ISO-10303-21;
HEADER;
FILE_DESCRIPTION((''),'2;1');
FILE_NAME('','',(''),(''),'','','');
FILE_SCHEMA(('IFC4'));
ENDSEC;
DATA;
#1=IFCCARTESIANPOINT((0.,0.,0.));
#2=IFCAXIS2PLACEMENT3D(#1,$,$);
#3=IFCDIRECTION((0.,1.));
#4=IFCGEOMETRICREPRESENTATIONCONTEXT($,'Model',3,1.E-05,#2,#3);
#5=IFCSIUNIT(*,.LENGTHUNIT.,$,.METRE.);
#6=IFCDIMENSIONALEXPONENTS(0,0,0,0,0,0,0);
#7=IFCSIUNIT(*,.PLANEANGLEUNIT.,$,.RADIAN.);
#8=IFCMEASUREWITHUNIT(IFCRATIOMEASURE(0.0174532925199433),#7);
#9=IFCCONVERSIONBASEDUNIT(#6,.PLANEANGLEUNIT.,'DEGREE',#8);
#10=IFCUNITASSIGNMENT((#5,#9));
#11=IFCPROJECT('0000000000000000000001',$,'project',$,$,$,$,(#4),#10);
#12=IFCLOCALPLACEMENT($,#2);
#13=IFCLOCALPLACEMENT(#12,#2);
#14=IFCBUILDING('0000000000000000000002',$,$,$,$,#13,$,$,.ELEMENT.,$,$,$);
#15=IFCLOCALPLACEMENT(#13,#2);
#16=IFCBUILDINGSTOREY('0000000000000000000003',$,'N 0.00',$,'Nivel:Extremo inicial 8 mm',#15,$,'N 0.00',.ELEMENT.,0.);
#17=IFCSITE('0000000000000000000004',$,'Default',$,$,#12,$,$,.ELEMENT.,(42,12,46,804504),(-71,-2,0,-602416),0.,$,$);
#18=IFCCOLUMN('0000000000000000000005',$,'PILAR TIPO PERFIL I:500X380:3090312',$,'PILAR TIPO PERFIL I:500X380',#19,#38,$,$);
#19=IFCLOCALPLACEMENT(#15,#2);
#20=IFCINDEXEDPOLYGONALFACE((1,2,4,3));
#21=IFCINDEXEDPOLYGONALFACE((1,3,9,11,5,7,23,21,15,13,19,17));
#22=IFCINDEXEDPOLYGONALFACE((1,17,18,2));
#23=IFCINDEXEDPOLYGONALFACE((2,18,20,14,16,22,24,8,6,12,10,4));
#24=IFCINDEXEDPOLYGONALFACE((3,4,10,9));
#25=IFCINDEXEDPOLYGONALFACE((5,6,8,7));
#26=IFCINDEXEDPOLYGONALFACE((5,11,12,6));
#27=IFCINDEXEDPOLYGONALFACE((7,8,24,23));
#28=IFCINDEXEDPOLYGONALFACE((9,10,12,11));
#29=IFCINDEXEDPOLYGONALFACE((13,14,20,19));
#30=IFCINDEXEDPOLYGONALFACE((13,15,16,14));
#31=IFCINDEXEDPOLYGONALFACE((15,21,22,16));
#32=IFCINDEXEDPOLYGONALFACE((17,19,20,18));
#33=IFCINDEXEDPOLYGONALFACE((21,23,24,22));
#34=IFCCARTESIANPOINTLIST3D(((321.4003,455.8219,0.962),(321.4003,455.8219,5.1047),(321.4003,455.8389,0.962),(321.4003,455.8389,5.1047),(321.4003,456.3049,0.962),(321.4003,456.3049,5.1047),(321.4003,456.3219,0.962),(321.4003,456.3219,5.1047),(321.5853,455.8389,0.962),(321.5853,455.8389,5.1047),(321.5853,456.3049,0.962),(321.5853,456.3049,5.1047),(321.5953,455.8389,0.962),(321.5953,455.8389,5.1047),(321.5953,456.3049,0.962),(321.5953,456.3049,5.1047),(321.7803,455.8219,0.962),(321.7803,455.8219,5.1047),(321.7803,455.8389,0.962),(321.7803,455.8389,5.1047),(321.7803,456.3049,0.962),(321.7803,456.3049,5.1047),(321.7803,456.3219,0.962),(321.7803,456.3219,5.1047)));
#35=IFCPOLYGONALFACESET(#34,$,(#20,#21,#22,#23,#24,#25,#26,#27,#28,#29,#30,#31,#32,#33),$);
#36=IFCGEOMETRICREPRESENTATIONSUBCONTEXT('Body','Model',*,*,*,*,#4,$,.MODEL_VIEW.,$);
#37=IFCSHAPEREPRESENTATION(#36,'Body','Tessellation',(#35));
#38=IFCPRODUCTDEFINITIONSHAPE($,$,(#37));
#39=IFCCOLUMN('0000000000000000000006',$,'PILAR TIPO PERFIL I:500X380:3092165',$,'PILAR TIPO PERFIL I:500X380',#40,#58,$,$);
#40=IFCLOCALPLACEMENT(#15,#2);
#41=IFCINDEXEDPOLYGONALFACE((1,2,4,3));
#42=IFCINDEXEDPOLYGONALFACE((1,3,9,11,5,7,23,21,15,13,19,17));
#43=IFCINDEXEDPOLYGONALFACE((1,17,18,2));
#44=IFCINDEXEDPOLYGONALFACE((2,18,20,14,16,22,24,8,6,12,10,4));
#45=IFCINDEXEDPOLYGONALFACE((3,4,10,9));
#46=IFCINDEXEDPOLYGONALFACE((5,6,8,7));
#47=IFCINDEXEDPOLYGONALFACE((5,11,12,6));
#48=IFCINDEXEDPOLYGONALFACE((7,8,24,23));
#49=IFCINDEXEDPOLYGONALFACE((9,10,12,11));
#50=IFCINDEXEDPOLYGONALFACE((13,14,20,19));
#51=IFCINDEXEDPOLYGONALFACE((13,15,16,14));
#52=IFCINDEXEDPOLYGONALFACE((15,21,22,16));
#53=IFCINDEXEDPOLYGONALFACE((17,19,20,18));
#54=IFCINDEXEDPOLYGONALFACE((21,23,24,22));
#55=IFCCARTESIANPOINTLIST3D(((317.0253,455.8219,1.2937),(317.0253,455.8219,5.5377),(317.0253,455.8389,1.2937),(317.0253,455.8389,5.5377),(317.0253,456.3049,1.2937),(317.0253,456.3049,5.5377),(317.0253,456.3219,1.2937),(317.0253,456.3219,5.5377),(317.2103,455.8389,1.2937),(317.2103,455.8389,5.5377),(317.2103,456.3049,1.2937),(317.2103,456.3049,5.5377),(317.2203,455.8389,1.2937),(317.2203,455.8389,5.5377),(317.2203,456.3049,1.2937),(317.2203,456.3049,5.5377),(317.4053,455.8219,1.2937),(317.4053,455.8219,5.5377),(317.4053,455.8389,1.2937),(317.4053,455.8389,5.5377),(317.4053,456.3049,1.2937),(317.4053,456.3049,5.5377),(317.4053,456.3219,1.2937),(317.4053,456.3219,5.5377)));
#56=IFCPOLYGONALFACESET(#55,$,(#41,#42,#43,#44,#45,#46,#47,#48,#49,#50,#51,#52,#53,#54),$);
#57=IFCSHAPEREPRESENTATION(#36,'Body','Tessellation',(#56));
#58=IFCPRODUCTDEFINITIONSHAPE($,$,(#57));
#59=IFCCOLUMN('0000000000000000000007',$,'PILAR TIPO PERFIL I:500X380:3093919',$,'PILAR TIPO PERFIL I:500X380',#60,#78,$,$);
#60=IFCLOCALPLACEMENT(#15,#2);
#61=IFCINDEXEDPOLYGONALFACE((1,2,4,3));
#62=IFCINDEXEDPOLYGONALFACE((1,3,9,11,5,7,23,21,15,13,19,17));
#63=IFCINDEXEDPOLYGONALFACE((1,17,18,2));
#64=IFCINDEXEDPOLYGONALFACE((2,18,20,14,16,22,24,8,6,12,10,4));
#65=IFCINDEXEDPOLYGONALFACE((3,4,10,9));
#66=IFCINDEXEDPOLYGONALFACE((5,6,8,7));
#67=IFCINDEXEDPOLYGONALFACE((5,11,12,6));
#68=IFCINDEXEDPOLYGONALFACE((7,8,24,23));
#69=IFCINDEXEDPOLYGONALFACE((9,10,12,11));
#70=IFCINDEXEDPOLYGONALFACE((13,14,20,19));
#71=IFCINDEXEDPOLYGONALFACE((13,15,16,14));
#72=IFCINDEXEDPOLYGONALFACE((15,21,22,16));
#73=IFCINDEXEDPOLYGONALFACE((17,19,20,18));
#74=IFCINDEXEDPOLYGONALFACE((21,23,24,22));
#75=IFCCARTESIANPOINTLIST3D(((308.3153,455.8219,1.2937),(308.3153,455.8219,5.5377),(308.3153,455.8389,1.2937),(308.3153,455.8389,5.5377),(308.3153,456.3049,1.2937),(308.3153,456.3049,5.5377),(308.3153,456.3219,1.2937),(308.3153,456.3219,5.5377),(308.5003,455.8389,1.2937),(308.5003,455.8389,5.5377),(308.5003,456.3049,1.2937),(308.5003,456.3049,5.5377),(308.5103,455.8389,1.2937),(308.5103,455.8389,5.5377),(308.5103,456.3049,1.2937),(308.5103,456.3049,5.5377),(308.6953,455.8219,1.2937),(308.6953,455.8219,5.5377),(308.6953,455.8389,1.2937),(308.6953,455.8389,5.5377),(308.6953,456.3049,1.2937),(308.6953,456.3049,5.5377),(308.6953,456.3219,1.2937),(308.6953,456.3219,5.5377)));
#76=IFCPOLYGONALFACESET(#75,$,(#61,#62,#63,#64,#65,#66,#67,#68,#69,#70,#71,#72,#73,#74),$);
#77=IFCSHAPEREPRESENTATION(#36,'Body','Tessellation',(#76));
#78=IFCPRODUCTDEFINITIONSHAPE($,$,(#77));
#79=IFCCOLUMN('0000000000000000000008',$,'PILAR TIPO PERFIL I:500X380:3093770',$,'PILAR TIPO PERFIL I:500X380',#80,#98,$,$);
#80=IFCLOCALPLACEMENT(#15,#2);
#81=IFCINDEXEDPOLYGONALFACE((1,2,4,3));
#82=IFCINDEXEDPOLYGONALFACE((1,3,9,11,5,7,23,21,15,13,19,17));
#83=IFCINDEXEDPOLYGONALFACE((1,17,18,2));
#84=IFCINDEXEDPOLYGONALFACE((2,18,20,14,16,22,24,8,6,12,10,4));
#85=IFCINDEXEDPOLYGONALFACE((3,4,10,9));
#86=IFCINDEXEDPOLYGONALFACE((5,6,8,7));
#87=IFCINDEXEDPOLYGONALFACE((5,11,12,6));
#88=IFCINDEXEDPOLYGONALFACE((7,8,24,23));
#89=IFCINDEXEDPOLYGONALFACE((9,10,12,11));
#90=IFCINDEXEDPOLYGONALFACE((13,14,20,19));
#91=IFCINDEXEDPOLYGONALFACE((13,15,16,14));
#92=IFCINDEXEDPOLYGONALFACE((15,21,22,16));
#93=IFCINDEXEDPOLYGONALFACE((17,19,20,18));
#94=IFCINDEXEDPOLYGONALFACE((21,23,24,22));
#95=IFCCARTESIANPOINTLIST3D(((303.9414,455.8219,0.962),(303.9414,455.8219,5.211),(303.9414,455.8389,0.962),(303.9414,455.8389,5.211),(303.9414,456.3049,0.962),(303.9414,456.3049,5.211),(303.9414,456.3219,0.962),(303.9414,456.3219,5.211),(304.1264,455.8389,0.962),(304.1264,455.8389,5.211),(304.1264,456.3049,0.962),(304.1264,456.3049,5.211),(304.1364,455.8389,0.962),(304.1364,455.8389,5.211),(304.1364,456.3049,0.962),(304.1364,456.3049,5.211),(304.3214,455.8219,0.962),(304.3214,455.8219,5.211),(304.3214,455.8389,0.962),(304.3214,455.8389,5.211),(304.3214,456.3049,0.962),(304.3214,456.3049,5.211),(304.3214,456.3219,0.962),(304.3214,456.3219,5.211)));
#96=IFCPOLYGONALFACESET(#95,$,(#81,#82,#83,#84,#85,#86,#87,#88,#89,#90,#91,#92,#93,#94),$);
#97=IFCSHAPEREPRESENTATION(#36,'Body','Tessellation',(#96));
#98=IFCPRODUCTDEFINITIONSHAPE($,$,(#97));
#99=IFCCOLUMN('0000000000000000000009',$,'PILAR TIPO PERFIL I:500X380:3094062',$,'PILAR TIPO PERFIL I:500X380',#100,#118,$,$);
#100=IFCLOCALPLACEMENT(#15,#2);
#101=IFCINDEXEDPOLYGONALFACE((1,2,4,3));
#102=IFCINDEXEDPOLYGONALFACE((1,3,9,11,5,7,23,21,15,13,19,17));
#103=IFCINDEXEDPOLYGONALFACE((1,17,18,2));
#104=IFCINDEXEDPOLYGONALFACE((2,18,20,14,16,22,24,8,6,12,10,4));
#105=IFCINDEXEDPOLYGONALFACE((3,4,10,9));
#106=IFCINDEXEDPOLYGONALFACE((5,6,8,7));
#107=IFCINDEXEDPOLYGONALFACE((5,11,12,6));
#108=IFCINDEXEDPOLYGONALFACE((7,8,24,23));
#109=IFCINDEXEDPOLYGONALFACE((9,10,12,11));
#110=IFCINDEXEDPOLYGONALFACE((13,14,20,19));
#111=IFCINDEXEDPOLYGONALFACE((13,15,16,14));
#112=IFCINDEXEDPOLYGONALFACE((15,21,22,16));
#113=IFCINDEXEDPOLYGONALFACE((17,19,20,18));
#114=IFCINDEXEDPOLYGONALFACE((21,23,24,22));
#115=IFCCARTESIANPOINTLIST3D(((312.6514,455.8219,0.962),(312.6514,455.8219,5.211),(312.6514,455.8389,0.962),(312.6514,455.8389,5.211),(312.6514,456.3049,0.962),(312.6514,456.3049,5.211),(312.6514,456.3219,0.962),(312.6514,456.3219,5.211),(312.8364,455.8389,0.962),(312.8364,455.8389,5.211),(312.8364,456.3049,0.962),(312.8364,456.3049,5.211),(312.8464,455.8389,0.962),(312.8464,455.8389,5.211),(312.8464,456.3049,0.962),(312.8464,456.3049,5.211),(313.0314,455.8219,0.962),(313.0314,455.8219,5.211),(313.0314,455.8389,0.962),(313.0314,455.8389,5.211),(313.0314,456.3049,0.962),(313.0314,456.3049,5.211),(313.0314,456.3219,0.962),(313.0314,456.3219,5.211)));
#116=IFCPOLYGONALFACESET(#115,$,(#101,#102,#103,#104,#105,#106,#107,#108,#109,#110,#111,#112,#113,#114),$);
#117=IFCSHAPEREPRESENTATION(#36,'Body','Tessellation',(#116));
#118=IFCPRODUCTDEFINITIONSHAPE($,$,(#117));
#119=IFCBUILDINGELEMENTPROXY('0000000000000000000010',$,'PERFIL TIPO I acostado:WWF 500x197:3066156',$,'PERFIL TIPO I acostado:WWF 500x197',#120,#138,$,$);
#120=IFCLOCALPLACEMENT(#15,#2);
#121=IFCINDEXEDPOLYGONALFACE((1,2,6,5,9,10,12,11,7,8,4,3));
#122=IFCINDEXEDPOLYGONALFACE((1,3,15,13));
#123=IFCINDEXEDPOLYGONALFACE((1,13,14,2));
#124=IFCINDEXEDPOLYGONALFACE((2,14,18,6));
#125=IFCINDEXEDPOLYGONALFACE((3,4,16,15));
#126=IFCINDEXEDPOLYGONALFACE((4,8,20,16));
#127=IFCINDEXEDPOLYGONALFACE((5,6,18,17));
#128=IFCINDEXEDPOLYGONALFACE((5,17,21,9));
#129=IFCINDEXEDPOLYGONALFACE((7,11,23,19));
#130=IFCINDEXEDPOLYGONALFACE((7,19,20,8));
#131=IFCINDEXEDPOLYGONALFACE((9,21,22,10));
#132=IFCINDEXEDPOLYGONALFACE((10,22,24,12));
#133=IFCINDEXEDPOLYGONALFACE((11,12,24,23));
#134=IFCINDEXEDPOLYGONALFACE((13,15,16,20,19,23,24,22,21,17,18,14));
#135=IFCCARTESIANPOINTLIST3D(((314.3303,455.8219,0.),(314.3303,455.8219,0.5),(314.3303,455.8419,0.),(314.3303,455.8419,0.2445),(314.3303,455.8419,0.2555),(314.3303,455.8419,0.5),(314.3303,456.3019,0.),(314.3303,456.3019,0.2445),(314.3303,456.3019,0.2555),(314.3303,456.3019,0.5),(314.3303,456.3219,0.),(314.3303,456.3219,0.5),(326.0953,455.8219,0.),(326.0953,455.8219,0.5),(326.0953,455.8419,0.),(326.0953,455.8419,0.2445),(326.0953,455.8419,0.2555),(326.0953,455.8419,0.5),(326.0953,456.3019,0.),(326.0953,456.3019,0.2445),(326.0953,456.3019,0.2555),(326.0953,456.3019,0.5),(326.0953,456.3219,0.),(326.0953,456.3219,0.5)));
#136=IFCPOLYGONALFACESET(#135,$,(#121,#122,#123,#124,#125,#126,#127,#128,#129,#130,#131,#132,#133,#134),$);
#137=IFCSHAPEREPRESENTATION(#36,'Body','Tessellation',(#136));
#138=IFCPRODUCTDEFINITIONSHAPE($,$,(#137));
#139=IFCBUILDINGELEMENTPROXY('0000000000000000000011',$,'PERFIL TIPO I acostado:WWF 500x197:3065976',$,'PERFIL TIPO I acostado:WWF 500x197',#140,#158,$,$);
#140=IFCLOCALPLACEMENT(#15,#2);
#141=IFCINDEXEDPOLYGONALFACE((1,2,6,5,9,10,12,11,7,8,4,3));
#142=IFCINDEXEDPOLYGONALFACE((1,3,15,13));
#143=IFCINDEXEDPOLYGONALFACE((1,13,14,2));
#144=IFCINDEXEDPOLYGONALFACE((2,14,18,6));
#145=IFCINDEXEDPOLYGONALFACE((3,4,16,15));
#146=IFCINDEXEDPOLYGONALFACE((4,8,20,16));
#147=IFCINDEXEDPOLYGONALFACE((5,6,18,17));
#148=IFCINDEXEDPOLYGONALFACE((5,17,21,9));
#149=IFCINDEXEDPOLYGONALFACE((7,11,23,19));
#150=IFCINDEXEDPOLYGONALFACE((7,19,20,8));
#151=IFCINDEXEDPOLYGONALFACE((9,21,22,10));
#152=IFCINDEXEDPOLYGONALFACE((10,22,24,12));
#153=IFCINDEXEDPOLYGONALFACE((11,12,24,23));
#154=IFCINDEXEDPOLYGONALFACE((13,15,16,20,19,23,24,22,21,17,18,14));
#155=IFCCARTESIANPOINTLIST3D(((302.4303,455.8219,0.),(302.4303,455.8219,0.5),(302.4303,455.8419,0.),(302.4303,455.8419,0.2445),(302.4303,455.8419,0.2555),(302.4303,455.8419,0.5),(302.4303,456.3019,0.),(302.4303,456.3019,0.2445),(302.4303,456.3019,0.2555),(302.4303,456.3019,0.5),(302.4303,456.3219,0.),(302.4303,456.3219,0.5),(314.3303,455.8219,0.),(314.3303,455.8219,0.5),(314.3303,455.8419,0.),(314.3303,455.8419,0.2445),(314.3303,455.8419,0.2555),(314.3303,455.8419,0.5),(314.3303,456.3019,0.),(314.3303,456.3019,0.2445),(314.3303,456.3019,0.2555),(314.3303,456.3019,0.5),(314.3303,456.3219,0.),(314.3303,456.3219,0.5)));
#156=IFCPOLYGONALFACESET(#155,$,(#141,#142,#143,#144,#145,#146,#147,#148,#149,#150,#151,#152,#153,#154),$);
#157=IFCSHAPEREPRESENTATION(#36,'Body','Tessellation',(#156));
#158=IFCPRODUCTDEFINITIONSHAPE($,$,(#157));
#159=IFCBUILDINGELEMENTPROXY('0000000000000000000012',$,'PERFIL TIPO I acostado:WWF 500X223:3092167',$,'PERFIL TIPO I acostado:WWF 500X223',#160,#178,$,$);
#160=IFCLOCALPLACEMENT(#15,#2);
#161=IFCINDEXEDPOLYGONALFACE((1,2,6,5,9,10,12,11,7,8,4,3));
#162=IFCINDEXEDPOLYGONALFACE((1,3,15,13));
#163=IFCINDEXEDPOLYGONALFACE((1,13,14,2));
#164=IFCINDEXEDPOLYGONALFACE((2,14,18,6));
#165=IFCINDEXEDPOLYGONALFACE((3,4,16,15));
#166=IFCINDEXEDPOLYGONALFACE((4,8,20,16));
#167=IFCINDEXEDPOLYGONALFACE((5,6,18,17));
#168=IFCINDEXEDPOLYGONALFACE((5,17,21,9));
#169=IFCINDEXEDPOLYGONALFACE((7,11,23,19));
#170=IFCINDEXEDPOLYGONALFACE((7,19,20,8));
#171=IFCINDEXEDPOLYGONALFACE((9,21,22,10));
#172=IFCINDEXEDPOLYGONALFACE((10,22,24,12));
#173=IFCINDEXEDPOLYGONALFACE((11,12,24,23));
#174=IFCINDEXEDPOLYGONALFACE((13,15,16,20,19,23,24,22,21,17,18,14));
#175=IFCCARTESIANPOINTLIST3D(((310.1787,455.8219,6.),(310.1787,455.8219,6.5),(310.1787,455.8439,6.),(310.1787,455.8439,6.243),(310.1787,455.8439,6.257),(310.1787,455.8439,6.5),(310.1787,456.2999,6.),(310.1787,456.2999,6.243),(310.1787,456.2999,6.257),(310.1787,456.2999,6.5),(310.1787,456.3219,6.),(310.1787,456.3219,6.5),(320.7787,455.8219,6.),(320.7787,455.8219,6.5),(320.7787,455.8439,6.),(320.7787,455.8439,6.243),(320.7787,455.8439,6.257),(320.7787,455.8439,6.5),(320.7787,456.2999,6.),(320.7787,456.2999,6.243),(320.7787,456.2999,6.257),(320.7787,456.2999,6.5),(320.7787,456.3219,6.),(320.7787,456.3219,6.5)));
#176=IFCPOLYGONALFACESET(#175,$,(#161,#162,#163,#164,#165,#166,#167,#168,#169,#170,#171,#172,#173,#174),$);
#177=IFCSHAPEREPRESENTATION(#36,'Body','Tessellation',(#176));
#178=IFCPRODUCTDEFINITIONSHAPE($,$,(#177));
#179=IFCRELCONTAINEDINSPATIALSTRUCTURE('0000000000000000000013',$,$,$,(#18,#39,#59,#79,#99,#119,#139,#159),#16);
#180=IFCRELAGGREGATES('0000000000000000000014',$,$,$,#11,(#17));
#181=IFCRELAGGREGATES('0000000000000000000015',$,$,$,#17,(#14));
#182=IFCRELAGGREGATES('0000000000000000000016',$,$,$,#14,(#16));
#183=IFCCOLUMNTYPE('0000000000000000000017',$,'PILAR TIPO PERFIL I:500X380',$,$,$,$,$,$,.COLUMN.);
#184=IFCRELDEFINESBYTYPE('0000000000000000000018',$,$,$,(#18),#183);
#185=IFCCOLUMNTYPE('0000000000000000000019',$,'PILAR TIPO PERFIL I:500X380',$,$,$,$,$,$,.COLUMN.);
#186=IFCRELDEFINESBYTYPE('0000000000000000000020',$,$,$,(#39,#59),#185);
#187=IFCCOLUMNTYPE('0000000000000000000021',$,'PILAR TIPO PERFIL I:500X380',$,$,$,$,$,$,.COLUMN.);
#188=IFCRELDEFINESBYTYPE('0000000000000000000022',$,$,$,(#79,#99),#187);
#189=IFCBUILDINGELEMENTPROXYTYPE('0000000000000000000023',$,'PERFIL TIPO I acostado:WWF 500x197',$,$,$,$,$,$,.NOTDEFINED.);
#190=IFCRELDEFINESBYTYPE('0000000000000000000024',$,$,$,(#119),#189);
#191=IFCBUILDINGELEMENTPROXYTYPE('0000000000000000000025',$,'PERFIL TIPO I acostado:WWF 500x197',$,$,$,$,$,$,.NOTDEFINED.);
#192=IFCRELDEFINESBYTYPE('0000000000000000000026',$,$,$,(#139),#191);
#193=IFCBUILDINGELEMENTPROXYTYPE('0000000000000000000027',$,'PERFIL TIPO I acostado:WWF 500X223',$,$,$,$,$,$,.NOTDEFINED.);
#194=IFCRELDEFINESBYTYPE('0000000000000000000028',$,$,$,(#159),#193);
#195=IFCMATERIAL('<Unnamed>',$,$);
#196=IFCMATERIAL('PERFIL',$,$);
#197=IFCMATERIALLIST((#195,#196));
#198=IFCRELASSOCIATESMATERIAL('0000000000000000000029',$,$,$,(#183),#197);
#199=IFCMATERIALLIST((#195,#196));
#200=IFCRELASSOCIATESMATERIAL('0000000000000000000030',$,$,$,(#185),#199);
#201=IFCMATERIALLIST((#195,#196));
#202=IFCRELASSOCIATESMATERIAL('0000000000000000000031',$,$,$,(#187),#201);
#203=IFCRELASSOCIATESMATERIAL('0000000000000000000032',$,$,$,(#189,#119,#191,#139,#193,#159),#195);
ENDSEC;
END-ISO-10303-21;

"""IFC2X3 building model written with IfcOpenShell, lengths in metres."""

from ifc_helpers import new_model, entity, si_unit, converted_unit, direction, frame, frame_2d, origin, place, context, subcontext, project, spatial, polyline, i_section, outline, extrude, source, transform, mapped, material, material_list, type_object, type_shapes, element, save


model = new_model("IFC2X3")

# Units and contexts
model_context = context("Model", 3, precision=1e-05, world=origin(), true_north=direction((0.0, 1.0)))
body_context = subcontext(model_context, "Body", "Model", "MODEL_VIEW")
ifc_project = project(units=[si_unit("LENGTHUNIT", "METRE"), converted_unit("PLANEANGLEUNIT", "DEGREE", entity("IfcRatioMeasure", 0.0174532925199433), si_unit("PLANEANGLEUNIT", "RADIAN"), dimensions=[0, 0, 0, 0, 0, 0, 0])], contexts=[model_context])

# Site, building, storey
site_placement = place(None, origin())
site = spatial("IfcSite", under=ifc_project, at=site_placement, Name="Default", CompositionType="ELEMENT", RefLatitude=(42, 12, 46, 804504), RefLongitude=(-71, -2, 0, -602416), RefElevation=0.0)
building_placement = place(site_placement, origin())
building = spatial("IfcBuilding", under=site, at=building_placement, CompositionType="ELEMENT")
storey_placement = place(building_placement, origin())
storey = spatial("IfcBuildingStorey", under=building, at=storey_placement, Name="N 0.00", ObjectType="Nivel:Extremo inicial 8 mm", LongName="N 0.00", CompositionType="ELEMENT", Elevation=0.0)

# Columns
ifc_material_1 = material(Name="<Unnamed>")
ifc_material_2 = material(Name="PERFIL")
ifc_material_list_1 = material_list([ifc_material_1, ifc_material_2])
column_type_1 = type_object("IfcColumnType", Name="PILAR TIPO PERFIL I:500X380", PredefinedType="COLUMN", material=ifc_material_list_1)
shared_shape_1 = source(origin(), body_context, "Body", "SweptSolid", [
    extrude(i_section(OverallWidth=0.38, OverallDepth=0.5, WebThickness=0.01, FlangeThickness=0.017, at=frame_2d((0.0, 0.0), x_axis=(1.0, 0.0))), frame((0.0, 0.0, 0.962), z_axis=(0.0, 0.0, 1.0), x_axis=(0.0, -1.0, 0.0)), (0.0, 0.0, 1.0), 4.1427),
])
type_shapes(column_type_1, [shared_shape_1])
column_placement = place(storey_placement, frame((321.5903, 456.0719, 0.0), z_axis=(0.0, 0.0, 1.0), x_axis=(0.0, 1.0, 0.0)))
element("IfcColumn", 1, at=column_placement, inside=storey, type_object=column_type_1, Name="PILAR TIPO PERFIL I:500X380:3090312", ObjectType="PILAR TIPO PERFIL I:500X380", context=body_context, shape_type="MappedRepresentation", body=[
    mapped(shared_shape_1, transform((0.0, 0.0, 0.0), scale=1.0)),
])
ifc_material_list_2 = material_list([ifc_material_1, ifc_material_2])
column_type_2 = type_object("IfcColumnType", Name="PILAR TIPO PERFIL I:500X380", PredefinedType="COLUMN", material=ifc_material_list_2)
shared_shape_2 = source(origin(), body_context, "Body", "SweptSolid", [
    extrude(i_section(OverallWidth=0.38, OverallDepth=0.5, WebThickness=0.01, FlangeThickness=0.017, at=frame_2d((0.0, 0.0), x_axis=(1.0, 0.0))), frame((0.0, 0.0, 1.2937), z_axis=(0.0, 0.0, 1.0), x_axis=(0.0, -1.0, 0.0)), (0.0, 0.0, 1.0), 4.244),
])
type_shapes(column_type_2, [shared_shape_2])
for number, where, z_axis, x_axis, name in (
    (2, (317.2153, 456.0719, 0.0), (0.0, 0.0, 1.0), (0.0, 1.0, 0.0), "PILAR TIPO PERFIL I:500X380:3092165"),
    (3, (308.5053, 456.0719, 0.0), (0.0, 0.0, 1.0), (0.0, 1.0, 0.0), "PILAR TIPO PERFIL I:500X380:3093919"),
):
    element("IfcColumn", number, at=place(storey_placement, frame(where, z_axis=z_axis, x_axis=x_axis)), inside=storey, type_object=column_type_2, Name=name, ObjectType="PILAR TIPO PERFIL I:500X380", context=body_context, shape_type="MappedRepresentation", body=[
        mapped(shared_shape_2, transform((0.0, 0.0, 0.0), scale=1.0)),
    ])
ifc_material_list_3 = material_list([ifc_material_1, ifc_material_2])
column_type_3 = type_object("IfcColumnType", Name="PILAR TIPO PERFIL I:500X380", PredefinedType="COLUMN", material=ifc_material_list_3)
shared_shape_3 = source(origin(), body_context, "Body", "SweptSolid", [
    extrude(i_section(OverallWidth=0.38, OverallDepth=0.5, WebThickness=0.01, FlangeThickness=0.017, at=frame_2d((0.0, 0.0), x_axis=(1.0, 0.0))), frame((0.0, 0.0, 0.962), z_axis=(0.0, 0.0, 1.0), x_axis=(0.0, -1.0, 0.0)), (0.0, 0.0, 1.0), 4.249),
])
type_shapes(column_type_3, [shared_shape_3])
for number, where, z_axis, x_axis, name in (
    (4, (304.1314, 456.0719, 0.0), (0.0, 0.0, 1.0), (0.0, 1.0, 0.0), "PILAR TIPO PERFIL I:500X380:3093770"),
    (5, (312.8414, 456.0719, 0.0), (0.0, 0.0, 1.0), (0.0, 1.0, 0.0), "PILAR TIPO PERFIL I:500X380:3094062"),
):
    element("IfcColumn", number, at=place(storey_placement, frame(where, z_axis=z_axis, x_axis=x_axis)), inside=storey, type_object=column_type_3, Name=name, ObjectType="PILAR TIPO PERFIL I:500X380", context=body_context, shape_type="MappedRepresentation", body=[
        mapped(shared_shape_3, transform((0.0, 0.0, 0.0), scale=1.0)),
    ])

# Building element proxies
building_element_proxy_type_1 = type_object("IfcBuildingElementProxyType", Name="PERFIL TIPO I acostado:WWF 500x197", PredefinedType="NOTDEFINED", material=ifc_material_1)
shared_shape_4 = source(origin(), body_context, "Body", "SweptSolid", [
    extrude(outline(polyline([(0.23, -0.25), (0.25, -0.25), (0.25, 0.25), (0.23, 0.25), (0.23, 0.0055), (-0.23, 0.0055), (-0.23, 0.25), (-0.25, 0.25), (-0.25, -0.25), (-0.23, -0.25), (-0.23, -0.0055), (0.23, -0.0055), (0.23, -0.25)])), frame((0.0, 0.0, 0.25), z_axis=(1.0, 0.0, 0.0), x_axis=(0.0, -1.0, 0.0)), (0.0, 0.0, 1.0), 11.765),
])
type_shapes(building_element_proxy_type_1, [shared_shape_4])
proxy_1_placement = place(storey_placement, frame((314.3303, 456.0719, 0.0)))
element("IfcBuildingElementProxy", 6, at=proxy_1_placement, inside=storey, type_object=building_element_proxy_type_1, material=ifc_material_1, Name="PERFIL TIPO I acostado:WWF 500x197:3066156", ObjectType="PERFIL TIPO I acostado:WWF 500x197", context=body_context, shape_type="MappedRepresentation", body=[
    mapped(shared_shape_4, transform((0.0, 0.0, 0.0), scale=1.0)),
])
building_element_proxy_type_2 = type_object("IfcBuildingElementProxyType", Name="PERFIL TIPO I acostado:WWF 500x197", PredefinedType="NOTDEFINED", material=ifc_material_1)
shared_shape_5 = source(origin(), body_context, "Body", "SweptSolid", [
    extrude(outline(polyline([(0.23, -0.25), (0.25, -0.25), (0.25, 0.25), (0.23, 0.25), (0.23, 0.0055), (-0.23, 0.0055), (-0.23, 0.25), (-0.25, 0.25), (-0.25, -0.25), (-0.23, -0.25), (-0.23, -0.0055), (0.23, -0.0055), (0.23, -0.25)])), frame((0.0, 0.0, 0.25), z_axis=(1.0, 0.0, 0.0), x_axis=(0.0, -1.0, 0.0)), (0.0, 0.0, 1.0), 11.9),
])
type_shapes(building_element_proxy_type_2, [shared_shape_5])
proxy_2_placement = place(storey_placement, frame((302.4303, 456.0719, 0.0)))
element("IfcBuildingElementProxy", 7, at=proxy_2_placement, inside=storey, type_object=building_element_proxy_type_2, material=ifc_material_1, Name="PERFIL TIPO I acostado:WWF 500x197:3065976", ObjectType="PERFIL TIPO I acostado:WWF 500x197", context=body_context, shape_type="MappedRepresentation", body=[
    mapped(shared_shape_5, transform((0.0, 0.0, 0.0), scale=1.0)),
])
building_element_proxy_type_3 = type_object("IfcBuildingElementProxyType", Name="PERFIL TIPO I acostado:WWF 500X223", PredefinedType="NOTDEFINED", material=ifc_material_1)
shared_shape_6 = source(origin(), body_context, "Body", "SweptSolid", [
    extrude(outline(polyline([(-0.25, -0.228), (-0.25, -0.25), (0.25, -0.25), (0.25, -0.228), (0.007, -0.228), (0.007, 0.228), (0.25, 0.228), (0.25, 0.25), (-0.25, 0.25), (-0.25, 0.228), (-0.007, 0.228), (-0.007, -0.228), (-0.25, -0.228)])), frame((0.0, 0.0, 0.25), z_axis=(-1.0, 0.0, 0.0), x_axis=(0.0, 0.0, -1.0)), (0.0, 0.0, -1.0), 10.6),
])
type_shapes(building_element_proxy_type_3, [shared_shape_6])
proxy_3_placement = place(storey_placement, frame((320.7787, 456.0719, 6.0), z_axis=(0.0, 0.0, 1.0), x_axis=(-1.0, 0.0, 0.0)))
element("IfcBuildingElementProxy", 8, at=proxy_3_placement, inside=storey, type_object=building_element_proxy_type_3, material=ifc_material_1, Name="PERFIL TIPO I acostado:WWF 500X223:3092167", ObjectType="PERFIL TIPO I acostado:WWF 500X223", context=body_context, shape_type="MappedRepresentation", body=[
    mapped(shared_shape_6, transform((0.0, 0.0, 0.0), scale=1.0)),
])

save(model, "model.ifc")
